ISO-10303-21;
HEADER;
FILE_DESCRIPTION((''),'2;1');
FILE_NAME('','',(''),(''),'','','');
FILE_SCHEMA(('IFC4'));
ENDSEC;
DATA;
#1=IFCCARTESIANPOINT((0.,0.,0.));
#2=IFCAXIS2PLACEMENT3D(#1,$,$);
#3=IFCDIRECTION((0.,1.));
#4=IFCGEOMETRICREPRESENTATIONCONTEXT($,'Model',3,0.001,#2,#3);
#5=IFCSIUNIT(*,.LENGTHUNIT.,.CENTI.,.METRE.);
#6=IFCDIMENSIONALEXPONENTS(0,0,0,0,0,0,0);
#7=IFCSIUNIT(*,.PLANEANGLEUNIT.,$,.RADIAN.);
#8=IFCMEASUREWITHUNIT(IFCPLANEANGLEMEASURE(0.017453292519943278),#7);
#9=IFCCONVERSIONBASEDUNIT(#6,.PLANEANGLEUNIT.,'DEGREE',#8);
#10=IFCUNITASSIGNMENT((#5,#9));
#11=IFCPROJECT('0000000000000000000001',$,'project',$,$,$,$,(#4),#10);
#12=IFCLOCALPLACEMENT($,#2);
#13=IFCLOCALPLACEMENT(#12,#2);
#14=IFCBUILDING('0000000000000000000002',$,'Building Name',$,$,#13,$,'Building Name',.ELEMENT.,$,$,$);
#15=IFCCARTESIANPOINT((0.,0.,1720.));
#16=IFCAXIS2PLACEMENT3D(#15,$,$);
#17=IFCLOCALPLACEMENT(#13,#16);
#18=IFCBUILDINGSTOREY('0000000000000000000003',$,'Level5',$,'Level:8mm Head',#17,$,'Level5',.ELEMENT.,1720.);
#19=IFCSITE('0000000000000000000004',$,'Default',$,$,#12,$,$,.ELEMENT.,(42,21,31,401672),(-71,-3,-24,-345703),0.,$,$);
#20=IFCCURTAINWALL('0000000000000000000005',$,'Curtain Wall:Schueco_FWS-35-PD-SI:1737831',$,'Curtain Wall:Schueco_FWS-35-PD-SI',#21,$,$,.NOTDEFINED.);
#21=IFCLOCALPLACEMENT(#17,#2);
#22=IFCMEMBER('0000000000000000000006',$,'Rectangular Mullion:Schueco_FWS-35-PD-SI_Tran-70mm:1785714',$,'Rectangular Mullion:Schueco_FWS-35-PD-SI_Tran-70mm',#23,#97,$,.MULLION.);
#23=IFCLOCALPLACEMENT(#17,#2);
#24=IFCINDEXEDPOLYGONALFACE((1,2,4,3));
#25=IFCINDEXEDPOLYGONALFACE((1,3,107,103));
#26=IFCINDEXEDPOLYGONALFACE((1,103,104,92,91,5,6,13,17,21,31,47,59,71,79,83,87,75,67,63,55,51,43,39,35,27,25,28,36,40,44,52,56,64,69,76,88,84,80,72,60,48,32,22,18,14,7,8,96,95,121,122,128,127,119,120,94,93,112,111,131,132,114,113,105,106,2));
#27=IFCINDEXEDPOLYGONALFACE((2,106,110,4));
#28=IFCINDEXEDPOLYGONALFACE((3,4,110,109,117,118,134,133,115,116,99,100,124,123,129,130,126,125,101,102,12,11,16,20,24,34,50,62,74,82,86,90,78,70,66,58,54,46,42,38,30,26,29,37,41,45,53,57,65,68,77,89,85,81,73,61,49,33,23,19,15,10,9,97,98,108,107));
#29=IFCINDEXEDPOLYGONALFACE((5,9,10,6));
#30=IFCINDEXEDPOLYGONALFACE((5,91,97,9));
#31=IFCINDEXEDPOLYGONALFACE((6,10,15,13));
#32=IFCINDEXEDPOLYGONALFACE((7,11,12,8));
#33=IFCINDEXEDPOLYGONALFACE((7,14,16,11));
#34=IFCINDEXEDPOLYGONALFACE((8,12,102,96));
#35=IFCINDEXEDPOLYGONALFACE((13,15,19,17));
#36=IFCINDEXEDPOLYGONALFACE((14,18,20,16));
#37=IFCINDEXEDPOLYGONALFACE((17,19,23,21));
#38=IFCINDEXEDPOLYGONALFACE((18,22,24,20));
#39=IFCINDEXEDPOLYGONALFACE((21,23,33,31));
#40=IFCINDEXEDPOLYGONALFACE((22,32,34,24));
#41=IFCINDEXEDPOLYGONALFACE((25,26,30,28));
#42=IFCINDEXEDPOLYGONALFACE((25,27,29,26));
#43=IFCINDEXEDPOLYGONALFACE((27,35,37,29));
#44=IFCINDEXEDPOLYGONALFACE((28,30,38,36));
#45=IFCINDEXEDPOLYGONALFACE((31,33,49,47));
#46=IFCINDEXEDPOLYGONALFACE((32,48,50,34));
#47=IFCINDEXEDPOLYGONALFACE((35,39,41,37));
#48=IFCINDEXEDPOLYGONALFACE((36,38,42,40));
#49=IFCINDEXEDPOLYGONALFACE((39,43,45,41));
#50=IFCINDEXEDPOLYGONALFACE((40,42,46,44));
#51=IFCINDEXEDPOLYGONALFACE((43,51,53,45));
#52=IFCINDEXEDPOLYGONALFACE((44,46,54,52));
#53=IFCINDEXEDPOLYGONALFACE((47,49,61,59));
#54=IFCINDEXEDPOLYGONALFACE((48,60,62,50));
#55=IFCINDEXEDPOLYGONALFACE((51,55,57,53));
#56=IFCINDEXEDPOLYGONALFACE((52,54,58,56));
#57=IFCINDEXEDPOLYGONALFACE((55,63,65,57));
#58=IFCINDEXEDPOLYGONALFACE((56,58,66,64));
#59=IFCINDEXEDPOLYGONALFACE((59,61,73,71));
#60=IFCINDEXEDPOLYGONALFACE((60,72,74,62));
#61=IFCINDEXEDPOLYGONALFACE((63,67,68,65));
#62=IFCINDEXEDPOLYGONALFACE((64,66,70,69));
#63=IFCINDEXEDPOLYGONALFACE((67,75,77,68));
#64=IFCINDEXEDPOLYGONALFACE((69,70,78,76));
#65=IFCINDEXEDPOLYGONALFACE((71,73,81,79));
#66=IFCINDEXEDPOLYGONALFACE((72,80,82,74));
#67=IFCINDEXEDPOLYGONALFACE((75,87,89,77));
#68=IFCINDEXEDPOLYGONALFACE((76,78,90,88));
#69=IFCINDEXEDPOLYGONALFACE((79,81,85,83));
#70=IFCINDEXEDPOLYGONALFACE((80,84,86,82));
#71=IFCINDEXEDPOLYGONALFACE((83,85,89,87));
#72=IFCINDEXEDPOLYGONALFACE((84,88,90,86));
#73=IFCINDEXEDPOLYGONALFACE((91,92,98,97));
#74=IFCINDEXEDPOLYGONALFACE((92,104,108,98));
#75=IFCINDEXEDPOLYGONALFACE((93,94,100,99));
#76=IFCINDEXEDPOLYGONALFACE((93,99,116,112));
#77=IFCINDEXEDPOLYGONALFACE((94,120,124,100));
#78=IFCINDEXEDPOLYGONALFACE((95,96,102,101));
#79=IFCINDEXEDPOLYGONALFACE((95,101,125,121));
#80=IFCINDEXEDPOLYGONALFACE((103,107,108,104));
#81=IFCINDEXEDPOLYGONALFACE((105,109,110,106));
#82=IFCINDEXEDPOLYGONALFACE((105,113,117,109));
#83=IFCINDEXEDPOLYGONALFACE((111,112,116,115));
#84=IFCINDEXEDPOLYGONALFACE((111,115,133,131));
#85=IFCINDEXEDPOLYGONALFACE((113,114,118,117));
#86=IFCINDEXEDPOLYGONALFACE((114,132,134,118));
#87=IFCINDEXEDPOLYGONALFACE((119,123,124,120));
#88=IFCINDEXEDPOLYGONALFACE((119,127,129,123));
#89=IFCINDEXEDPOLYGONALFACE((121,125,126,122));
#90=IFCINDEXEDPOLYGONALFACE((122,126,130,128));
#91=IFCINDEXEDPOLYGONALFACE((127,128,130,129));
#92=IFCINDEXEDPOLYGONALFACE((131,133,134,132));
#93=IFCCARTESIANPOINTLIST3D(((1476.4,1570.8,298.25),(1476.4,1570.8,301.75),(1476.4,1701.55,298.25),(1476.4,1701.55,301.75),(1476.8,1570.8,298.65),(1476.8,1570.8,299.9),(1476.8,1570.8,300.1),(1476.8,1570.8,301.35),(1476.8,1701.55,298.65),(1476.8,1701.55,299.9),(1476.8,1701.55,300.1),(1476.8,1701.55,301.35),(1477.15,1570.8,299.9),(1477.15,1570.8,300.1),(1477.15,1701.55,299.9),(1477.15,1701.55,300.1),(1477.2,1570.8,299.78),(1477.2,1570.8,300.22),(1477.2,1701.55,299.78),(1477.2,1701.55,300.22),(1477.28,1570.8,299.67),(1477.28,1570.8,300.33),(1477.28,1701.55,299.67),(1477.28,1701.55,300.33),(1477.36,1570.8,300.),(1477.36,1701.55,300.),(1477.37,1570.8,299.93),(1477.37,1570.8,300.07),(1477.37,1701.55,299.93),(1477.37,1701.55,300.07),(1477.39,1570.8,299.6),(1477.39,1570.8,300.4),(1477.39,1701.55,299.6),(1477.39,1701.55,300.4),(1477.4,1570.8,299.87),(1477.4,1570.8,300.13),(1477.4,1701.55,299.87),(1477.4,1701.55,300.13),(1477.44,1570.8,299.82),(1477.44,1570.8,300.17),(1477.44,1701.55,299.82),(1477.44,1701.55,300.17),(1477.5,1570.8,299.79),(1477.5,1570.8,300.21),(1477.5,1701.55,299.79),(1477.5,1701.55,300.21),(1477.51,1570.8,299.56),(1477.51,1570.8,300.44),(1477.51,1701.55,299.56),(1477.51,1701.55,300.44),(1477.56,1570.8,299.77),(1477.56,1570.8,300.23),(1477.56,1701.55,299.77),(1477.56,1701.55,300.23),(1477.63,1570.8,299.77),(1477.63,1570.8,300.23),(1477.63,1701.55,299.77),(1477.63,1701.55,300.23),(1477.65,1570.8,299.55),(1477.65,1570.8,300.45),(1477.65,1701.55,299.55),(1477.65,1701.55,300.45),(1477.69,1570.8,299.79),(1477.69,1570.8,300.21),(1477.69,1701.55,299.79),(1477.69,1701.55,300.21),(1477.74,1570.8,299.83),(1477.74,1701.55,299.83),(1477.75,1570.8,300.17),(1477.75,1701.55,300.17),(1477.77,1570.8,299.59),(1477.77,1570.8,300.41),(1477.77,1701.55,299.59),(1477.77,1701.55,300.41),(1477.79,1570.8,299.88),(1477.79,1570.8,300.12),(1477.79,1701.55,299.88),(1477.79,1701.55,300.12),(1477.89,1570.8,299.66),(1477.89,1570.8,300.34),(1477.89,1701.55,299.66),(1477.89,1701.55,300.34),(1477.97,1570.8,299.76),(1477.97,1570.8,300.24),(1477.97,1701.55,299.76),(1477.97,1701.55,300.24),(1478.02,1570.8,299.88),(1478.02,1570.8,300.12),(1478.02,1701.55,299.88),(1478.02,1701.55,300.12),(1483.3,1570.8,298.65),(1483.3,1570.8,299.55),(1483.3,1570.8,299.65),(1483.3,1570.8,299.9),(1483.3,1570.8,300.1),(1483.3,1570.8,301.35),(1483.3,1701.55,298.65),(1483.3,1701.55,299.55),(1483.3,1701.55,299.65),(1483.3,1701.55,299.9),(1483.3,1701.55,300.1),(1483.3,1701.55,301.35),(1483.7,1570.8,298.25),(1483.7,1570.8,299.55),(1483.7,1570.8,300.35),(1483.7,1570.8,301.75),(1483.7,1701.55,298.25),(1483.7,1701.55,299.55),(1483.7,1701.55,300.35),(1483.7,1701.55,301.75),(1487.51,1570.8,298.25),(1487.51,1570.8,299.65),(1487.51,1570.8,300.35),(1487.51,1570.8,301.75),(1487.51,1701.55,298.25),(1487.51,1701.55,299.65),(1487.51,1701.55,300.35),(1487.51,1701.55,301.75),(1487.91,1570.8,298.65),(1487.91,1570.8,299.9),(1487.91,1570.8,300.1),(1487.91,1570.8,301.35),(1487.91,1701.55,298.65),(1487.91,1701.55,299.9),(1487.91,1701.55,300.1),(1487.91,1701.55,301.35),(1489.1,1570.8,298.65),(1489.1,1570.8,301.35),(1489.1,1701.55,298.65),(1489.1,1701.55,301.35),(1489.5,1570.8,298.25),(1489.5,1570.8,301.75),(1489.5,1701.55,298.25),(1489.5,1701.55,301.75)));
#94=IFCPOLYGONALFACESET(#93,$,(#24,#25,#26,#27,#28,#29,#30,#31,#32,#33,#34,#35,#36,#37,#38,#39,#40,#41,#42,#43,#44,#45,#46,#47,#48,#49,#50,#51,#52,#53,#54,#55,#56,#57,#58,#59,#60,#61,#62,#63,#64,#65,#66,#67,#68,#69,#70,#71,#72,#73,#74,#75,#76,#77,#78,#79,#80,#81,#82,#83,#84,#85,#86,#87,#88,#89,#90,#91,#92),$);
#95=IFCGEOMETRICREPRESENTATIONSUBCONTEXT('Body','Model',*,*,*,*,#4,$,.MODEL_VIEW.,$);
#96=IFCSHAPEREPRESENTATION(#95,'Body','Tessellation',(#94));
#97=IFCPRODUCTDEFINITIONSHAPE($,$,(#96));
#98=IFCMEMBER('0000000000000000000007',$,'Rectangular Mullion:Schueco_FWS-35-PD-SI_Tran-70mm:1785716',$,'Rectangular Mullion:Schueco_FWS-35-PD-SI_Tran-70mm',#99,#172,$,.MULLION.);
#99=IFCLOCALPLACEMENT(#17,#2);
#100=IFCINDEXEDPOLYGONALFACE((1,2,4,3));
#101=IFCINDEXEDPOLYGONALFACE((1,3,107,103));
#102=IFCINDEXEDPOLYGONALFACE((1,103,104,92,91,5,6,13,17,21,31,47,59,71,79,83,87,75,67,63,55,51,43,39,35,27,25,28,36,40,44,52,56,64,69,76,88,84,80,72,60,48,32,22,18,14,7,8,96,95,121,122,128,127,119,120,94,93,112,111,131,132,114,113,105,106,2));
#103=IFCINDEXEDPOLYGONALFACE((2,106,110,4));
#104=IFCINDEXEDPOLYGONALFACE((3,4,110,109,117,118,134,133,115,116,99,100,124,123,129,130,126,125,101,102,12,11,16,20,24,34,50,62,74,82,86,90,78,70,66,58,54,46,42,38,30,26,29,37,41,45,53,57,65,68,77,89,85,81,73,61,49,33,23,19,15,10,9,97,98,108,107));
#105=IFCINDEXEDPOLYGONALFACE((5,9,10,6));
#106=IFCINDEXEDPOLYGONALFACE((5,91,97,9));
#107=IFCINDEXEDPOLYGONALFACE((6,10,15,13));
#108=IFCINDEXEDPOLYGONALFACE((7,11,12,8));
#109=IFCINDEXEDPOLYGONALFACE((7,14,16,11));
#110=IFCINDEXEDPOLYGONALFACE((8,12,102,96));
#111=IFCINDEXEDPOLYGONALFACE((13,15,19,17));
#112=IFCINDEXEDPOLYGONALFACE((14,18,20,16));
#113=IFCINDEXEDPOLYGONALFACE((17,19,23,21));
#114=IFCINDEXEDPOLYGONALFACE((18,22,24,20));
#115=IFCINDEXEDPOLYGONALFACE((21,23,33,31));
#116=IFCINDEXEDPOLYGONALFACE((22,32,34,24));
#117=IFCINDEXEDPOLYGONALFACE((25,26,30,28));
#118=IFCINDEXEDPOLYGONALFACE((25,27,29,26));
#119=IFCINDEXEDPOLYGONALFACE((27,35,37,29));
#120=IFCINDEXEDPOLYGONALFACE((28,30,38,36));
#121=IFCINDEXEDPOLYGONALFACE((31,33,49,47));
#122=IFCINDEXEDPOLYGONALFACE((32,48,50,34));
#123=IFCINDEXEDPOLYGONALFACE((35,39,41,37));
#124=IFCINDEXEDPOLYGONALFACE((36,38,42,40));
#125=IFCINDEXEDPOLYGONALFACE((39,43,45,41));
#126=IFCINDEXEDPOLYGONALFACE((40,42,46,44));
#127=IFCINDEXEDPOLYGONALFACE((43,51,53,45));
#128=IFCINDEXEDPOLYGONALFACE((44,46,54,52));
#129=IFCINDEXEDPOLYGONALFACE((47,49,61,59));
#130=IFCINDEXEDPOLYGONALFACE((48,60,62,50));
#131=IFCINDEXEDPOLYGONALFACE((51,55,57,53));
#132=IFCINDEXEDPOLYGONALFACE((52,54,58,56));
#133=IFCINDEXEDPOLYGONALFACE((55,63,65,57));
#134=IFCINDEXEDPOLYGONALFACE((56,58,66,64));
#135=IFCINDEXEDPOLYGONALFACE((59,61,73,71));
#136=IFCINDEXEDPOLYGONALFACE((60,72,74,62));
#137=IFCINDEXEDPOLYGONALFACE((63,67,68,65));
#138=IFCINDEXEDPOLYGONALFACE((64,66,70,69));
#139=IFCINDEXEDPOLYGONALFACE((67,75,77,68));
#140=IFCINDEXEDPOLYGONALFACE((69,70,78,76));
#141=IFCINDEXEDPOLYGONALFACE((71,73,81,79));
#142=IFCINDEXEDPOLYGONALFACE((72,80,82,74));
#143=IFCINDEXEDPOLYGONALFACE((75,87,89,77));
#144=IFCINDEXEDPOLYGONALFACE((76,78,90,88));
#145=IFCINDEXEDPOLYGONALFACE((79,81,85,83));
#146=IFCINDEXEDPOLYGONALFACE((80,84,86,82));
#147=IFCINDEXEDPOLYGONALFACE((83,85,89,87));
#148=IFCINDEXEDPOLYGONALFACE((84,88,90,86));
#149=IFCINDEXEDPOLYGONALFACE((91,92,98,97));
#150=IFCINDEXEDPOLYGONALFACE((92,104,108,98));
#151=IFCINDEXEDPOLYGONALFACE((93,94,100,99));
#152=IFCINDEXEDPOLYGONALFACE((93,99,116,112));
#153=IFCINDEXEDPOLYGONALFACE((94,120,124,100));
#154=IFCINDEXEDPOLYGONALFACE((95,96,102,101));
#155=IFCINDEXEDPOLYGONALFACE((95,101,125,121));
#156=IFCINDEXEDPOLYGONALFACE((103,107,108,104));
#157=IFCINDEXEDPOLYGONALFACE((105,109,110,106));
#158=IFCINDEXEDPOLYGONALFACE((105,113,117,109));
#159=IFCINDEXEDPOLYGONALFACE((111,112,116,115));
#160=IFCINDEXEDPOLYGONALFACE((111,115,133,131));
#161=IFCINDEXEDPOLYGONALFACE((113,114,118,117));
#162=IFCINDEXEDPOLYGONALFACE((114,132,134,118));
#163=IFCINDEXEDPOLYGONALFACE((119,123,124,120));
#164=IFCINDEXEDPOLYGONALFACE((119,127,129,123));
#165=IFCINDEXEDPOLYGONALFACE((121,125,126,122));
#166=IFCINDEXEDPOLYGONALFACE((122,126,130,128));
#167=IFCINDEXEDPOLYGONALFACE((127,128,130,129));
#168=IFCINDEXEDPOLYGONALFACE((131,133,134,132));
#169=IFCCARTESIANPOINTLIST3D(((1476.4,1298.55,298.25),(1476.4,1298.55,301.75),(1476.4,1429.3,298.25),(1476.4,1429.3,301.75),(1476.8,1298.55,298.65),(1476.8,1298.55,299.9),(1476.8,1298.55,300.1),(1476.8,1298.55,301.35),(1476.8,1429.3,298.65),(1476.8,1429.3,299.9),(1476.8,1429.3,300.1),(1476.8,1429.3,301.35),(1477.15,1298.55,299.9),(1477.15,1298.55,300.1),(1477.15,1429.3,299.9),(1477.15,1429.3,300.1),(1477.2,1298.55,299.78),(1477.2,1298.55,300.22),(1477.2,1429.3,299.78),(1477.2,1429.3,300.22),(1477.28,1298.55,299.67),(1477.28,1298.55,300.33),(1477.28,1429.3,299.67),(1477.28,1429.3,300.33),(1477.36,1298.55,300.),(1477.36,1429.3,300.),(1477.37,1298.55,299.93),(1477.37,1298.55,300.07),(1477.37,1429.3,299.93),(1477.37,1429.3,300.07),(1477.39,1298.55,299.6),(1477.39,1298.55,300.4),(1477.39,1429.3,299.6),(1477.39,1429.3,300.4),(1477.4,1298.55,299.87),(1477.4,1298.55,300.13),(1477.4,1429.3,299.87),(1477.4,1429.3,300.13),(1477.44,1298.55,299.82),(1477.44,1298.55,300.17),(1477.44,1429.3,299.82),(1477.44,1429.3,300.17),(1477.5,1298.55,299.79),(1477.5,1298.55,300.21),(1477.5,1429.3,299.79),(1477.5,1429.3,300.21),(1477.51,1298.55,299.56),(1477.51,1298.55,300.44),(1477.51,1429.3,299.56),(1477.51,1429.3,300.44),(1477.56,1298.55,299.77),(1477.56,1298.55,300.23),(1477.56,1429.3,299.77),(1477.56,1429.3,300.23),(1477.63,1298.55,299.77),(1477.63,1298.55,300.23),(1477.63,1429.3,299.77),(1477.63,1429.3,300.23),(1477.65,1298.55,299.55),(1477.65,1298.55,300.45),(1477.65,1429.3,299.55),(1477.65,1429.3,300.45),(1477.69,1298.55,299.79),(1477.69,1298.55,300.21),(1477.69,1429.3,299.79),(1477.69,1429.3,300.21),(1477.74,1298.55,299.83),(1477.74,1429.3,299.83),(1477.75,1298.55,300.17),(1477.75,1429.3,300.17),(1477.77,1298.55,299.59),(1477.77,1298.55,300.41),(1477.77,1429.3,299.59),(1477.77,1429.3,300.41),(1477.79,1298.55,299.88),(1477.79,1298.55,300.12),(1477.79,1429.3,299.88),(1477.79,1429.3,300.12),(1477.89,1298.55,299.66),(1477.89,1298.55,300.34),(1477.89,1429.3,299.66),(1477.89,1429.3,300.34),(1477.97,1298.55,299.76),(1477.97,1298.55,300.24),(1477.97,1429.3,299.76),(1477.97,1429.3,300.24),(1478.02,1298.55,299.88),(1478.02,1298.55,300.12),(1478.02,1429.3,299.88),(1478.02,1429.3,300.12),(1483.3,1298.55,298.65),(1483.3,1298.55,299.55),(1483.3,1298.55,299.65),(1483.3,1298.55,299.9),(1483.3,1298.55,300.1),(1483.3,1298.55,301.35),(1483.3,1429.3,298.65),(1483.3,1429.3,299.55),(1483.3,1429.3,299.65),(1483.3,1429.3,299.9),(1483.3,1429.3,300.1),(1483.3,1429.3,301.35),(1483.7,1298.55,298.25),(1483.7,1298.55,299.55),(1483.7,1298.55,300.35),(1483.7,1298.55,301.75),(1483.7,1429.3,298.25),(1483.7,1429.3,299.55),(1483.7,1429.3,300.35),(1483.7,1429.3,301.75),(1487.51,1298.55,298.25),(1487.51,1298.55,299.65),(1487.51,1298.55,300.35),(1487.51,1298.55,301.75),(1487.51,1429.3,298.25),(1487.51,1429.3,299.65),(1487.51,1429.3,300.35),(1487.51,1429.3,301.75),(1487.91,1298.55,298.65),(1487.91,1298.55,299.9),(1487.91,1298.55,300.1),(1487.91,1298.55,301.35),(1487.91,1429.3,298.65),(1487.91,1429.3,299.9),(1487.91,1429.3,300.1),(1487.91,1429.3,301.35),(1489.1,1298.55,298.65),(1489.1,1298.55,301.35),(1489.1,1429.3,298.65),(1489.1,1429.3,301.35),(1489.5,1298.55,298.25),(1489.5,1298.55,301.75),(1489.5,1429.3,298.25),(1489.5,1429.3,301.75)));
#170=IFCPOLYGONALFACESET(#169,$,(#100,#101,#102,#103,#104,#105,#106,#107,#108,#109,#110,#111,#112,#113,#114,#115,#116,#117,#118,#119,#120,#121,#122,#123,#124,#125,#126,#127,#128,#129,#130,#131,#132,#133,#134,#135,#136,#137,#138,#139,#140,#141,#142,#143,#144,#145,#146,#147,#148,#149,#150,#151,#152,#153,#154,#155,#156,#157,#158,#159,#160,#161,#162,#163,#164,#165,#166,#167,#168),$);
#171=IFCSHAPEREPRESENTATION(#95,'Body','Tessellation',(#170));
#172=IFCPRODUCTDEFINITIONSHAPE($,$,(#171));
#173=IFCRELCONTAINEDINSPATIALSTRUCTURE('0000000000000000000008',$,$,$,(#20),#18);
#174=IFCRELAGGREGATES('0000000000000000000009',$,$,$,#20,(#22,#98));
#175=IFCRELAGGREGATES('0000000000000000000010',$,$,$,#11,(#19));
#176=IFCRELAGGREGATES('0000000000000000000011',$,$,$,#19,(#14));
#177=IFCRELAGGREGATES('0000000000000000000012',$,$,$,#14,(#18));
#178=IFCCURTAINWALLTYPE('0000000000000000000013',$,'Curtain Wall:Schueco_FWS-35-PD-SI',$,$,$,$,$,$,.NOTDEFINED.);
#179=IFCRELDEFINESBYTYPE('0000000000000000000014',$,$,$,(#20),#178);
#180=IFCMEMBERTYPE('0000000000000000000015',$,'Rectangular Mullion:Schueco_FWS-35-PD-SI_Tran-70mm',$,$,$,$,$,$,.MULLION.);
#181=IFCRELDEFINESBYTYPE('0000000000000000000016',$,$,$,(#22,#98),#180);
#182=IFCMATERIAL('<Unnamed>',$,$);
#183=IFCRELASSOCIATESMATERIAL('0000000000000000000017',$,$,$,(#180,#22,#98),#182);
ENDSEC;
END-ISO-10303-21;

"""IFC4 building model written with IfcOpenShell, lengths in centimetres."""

from ifc_helpers import new_model, entity, si_unit, converted_unit, direction, frame, origin, place, context, subcontext, project, spatial, line, arc, indexed_curve, outline, extrude, source, transform, mapped, material, type_object, type_shapes, element, aggregate, save


model = new_model("IFC4")

# Units and contexts
model_context = context("Model", 3, precision=0.001, world=origin(), true_north=direction((0.0, 1.0)))
body_context = subcontext(model_context, "Body", "Model", "MODEL_VIEW")
ifc_project = project(units=[si_unit("LENGTHUNIT", "METRE", prefix="CENTI"), converted_unit("PLANEANGLEUNIT", "DEGREE", entity("IfcPlaneAngleMeasure", 0.017453292519943278), si_unit("PLANEANGLEUNIT", "RADIAN"), dimensions=[0, 0, 0, 0, 0, 0, 0])], contexts=[model_context])

# Site, building, storey
site_placement = place(None, origin())
site = spatial("IfcSite", under=ifc_project, at=site_placement, Name="Default", CompositionType="ELEMENT", RefLatitude=(42, 21, 31, 401672), RefLongitude=(-71, -3, -24, -345703), RefElevation=0.0)
building_placement = place(site_placement, origin())
building = spatial("IfcBuilding", under=site, at=building_placement, Name="Building Name", LongName="Building Name", CompositionType="ELEMENT")
storey_placement = place(building_placement, frame((0.0, 0.0, 1720.0)))
storey = spatial("IfcBuildingStorey", under=building, at=storey_placement, Name="Level5", ObjectType="Level:8mm Head", LongName="Level5", CompositionType="ELEMENT", Elevation=1720.0)

# Curtain wall, members
curtain_wall_type = type_object("IfcCurtainWallType", Name="Curtain Wall:Schueco_FWS-35-PD-SI", PredefinedType="NOTDEFINED")
curtain_wall_placement = place(storey_placement, frame((0.0, 0.0, -1720.0)))
curtain_wall = element("IfcCurtainWall", 1, at=curtain_wall_placement, inside=storey, type_object=curtain_wall_type, Name="Curtain Wall:Schueco_FWS-35-PD-SI:1737831", ObjectType="Curtain Wall:Schueco_FWS-35-PD-SI", PredefinedType="NOTDEFINED")
ifc_material_1 = material(Name="<Unnamed>")
member_type_1 = type_object("IfcMemberType", Name="Rectangular Mullion:Schueco_FWS-35-PD-SI_Tran-70mm", PredefinedType="MULLION", material=ifc_material_1)
shared_shape_1 = source(origin(), body_context, "Body", "SweptSolid", [
    extrude(outline(indexed_curve([(-1.78, -6.52), (1.72, -6.52), (1.72, 0.78), (0.42, 0.78), (0.42, 0.38), (1.32, 0.38), (1.32, -6.12), (0.07, -6.12), (0.07, -5.77), (0.42, -5.34), (0.09, -4.9), (0.09, -5.14), (-0.03, -5.56), (-0.15, -5.14), (-0.15, -4.9), (-0.48, -5.34), (-0.13, -5.77), (-0.13, -6.12), (-1.38, -6.12), (-1.38, 0.38), (-0.13, 0.38), (-0.13, 4.99), (-1.38, 4.99), (-1.38, 6.18), (1.32, 6.18), (1.32, 4.99), (0.07, 4.99), (0.07, 0.38), (0.32, 0.38), (0.32, 4.59), (1.72, 4.59), (1.72, 6.58), (-1.78, 6.58), (-1.78, 4.59), (-0.38, 4.59), (-0.38, 0.78), (-1.78, 0.78)], segments=[line(1, 2, 3, 4, 5, 6, 7, 8, 9), arc(9, 10, 11), line(11, 12), arc(12, 13, 14), line(14, 15), arc(15, 16, 17), line(17, 18, 19, 20, 21, 22, 23, 24, 25, 26, 27, 28, 29, 30, 31, 32, 33, 34, 35, 36, 37, 1)], self_intersect=False)), frame((-0.03, 4.58, -130.75), z_axis=(0.0, 0.0, 1.0), x_axis=(-1.0, 0.0, 0.0)), (0.0, 0.0, 1.0), 130.75),
])
type_shapes(member_type_1, [shared_shape_1])
member_1_placement = place(curtain_wall_placement, frame((1487.5, 1570.8, 2020.0), z_axis=(0.0, -1.0, 0.0), x_axis=(0.0, 0.0, 1.0)))
member_1 = element("IfcMember", 2, at=member_1_placement, type_object=member_type_1, material=ifc_material_1, Name="Rectangular Mullion:Schueco_FWS-35-PD-SI_Tran-70mm:1785714", ObjectType="Rectangular Mullion:Schueco_FWS-35-PD-SI_Tran-70mm", PredefinedType="MULLION", context=body_context, shape_type="MappedRepresentation", body=[
    mapped(shared_shape_1, transform((0.0, 0.0, 0.0), scale=1.0)),
])
member_2_placement = place(curtain_wall_placement, frame((1487.5, 1298.55, 2020.0), z_axis=(0.0, -1.0, 0.0), x_axis=(0.0, 0.0, 1.0)))
member_2 = element("IfcMember", 3, at=member_2_placement, type_object=member_type_1, material=ifc_material_1, Name="Rectangular Mullion:Schueco_FWS-35-PD-SI_Tran-70mm:1785716", ObjectType="Rectangular Mullion:Schueco_FWS-35-PD-SI_Tran-70mm", PredefinedType="MULLION", context=body_context, shape_type="MappedRepresentation", body=[
    mapped(shared_shape_1, transform((0.0, 0.0, 0.0), scale=1.0)),
])
aggregate(curtain_wall, [member_1, member_2])

save(model, "model.ifc")
